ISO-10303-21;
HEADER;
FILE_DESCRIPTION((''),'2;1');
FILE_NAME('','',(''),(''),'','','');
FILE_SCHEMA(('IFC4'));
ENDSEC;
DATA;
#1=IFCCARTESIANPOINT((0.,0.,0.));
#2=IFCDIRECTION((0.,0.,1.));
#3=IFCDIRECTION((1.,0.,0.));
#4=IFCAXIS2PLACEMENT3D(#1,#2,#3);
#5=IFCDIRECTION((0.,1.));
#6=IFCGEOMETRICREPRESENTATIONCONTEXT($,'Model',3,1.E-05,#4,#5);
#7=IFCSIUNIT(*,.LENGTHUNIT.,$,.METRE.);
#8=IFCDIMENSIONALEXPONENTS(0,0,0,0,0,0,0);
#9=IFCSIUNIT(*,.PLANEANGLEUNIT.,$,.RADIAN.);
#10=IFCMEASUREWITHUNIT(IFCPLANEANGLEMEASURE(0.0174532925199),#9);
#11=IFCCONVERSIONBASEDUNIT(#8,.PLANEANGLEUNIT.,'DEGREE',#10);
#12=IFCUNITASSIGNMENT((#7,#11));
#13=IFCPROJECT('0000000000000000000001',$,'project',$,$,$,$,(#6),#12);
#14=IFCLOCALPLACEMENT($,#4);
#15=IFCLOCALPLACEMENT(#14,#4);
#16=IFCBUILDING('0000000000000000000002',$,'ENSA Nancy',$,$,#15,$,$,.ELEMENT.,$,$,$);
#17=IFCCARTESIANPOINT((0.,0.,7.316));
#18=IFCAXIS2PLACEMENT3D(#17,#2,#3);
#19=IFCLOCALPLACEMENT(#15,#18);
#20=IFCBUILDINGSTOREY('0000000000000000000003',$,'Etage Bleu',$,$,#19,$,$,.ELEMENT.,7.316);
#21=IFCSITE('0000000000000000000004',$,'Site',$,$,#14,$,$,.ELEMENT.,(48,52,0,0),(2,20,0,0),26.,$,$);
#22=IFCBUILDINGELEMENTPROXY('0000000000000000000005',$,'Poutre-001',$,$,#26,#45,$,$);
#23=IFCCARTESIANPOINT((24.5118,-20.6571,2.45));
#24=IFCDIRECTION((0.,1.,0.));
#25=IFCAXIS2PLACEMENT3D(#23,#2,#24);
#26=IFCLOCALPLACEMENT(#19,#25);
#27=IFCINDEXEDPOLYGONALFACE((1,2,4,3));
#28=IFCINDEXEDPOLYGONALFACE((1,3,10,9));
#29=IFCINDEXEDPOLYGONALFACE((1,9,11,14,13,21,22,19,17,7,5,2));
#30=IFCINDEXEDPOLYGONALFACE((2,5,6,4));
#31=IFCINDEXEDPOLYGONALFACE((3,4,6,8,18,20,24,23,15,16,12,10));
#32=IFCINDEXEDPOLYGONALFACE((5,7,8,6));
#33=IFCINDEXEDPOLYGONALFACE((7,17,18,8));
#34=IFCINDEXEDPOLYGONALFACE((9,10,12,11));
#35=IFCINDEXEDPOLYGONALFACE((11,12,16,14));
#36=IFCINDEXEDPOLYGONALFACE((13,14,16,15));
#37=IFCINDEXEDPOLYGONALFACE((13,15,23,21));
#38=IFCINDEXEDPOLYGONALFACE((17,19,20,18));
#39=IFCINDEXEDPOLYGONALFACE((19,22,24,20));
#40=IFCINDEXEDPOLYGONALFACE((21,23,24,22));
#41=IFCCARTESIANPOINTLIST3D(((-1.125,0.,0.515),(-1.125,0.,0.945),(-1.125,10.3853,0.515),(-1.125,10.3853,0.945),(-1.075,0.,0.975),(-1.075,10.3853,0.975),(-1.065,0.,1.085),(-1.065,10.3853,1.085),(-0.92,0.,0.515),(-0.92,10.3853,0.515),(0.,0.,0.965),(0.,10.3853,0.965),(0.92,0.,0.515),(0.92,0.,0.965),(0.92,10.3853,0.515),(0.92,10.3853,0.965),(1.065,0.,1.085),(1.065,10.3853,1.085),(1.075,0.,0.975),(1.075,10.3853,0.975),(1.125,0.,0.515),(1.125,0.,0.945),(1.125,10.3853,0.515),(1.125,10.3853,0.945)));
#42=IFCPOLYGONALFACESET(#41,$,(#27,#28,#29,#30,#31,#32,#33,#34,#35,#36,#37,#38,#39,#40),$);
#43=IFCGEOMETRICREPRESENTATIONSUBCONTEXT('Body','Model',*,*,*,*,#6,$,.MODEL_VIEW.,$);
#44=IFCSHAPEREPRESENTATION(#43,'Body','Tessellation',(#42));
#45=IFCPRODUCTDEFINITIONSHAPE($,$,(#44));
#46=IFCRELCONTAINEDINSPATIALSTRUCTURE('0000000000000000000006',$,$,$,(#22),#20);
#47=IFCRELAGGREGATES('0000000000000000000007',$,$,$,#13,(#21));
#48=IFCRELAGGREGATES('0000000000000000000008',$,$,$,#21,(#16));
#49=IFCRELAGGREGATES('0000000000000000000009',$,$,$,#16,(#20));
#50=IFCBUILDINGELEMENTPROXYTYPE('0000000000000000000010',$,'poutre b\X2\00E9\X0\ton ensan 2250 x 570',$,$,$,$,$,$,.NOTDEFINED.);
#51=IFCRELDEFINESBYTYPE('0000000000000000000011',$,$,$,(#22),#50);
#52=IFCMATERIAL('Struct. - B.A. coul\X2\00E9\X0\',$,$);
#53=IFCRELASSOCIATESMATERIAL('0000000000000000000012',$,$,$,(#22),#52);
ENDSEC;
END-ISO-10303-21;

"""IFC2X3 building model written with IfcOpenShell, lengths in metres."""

from ifc_helpers import new_model, entity, si_unit, converted_unit, direction, frame, origin_with_axes, place, context, subcontext, project, spatial, polyline, outline, extrude, material, type_object, element, save


model = new_model("IFC2X3")

# Units and contexts
model_context = context("Model", 3, precision=1e-05, world=origin_with_axes(), true_north=direction((0.0, 1.0)))
body_context = subcontext(model_context, "Body", "Model", "MODEL_VIEW")
ifc_project = project(units=[si_unit("LENGTHUNIT", "METRE"), converted_unit("PLANEANGLEUNIT", "DEGREE", entity("IfcPlaneAngleMeasure", 0.0174532925199), si_unit("PLANEANGLEUNIT", "RADIAN"), dimensions=[0, 0, 0, 0, 0, 0, 0])], contexts=[model_context])

# Site, building, storey
site_placement = place(None, origin_with_axes())
site = spatial("IfcSite", under=ifc_project, at=site_placement, Name="Site", CompositionType="ELEMENT", RefLatitude=(48, 52, 0, 0), RefLongitude=(2, 20, 0, 0), RefElevation=26.0)
building_placement = place(site_placement, origin_with_axes())
building = spatial("IfcBuilding", under=site, at=building_placement, Name="ENSA Nancy", CompositionType="ELEMENT")
storey_placement = place(building_placement, frame((0.0, 0.0, 7.316), z_axis=(0.0, 0.0, 1.0), x_axis=(1.0, 0.0, 0.0)))
storey = spatial("IfcBuildingStorey", under=building, at=storey_placement, Name="Etage Bleu", CompositionType="ELEMENT", Elevation=7.316)

# Building element proxy
ifc_material_1 = material(Name="Struct. - B.A. coulé")
building_element_proxy_type_1 = type_object("IfcBuildingElementProxyType", Name="poutre béton ensan 2250 x 570", PredefinedType="NOTDEFINED")
proxy_1_placement = place(storey_placement, frame((24.5118, -20.6571, 2.45), z_axis=(0.0, 0.0, 1.0), x_axis=(0.0, 1.0, 0.0)))
element("IfcBuildingElementProxy", 1, at=proxy_1_placement, inside=storey, type_object=building_element_proxy_type_1, material=ifc_material_1, Name="Poutre-001", context=body_context, shape_type="SweptSolid", body=[
    extrude(outline(polyline([(-1.065, 1.085), (-1.075, 0.975), (-1.125, 0.945), (-1.125, 0.515), (-0.92, 0.515), (0.0, 0.965), (0.92, 0.965), (0.92, 0.515), (1.125, 0.515), (1.125, 0.945), (1.075, 0.975), (1.065, 1.085), (-1.065, 1.085)])), frame((0.0, 10.3853, 0.0), z_axis=(0.0, -1.0, 0.0), x_axis=(1.0, 0.0, 0.0)), (0.0, 0.0, 1.0), 10.3853),
])

save(model, "model.ifc")
